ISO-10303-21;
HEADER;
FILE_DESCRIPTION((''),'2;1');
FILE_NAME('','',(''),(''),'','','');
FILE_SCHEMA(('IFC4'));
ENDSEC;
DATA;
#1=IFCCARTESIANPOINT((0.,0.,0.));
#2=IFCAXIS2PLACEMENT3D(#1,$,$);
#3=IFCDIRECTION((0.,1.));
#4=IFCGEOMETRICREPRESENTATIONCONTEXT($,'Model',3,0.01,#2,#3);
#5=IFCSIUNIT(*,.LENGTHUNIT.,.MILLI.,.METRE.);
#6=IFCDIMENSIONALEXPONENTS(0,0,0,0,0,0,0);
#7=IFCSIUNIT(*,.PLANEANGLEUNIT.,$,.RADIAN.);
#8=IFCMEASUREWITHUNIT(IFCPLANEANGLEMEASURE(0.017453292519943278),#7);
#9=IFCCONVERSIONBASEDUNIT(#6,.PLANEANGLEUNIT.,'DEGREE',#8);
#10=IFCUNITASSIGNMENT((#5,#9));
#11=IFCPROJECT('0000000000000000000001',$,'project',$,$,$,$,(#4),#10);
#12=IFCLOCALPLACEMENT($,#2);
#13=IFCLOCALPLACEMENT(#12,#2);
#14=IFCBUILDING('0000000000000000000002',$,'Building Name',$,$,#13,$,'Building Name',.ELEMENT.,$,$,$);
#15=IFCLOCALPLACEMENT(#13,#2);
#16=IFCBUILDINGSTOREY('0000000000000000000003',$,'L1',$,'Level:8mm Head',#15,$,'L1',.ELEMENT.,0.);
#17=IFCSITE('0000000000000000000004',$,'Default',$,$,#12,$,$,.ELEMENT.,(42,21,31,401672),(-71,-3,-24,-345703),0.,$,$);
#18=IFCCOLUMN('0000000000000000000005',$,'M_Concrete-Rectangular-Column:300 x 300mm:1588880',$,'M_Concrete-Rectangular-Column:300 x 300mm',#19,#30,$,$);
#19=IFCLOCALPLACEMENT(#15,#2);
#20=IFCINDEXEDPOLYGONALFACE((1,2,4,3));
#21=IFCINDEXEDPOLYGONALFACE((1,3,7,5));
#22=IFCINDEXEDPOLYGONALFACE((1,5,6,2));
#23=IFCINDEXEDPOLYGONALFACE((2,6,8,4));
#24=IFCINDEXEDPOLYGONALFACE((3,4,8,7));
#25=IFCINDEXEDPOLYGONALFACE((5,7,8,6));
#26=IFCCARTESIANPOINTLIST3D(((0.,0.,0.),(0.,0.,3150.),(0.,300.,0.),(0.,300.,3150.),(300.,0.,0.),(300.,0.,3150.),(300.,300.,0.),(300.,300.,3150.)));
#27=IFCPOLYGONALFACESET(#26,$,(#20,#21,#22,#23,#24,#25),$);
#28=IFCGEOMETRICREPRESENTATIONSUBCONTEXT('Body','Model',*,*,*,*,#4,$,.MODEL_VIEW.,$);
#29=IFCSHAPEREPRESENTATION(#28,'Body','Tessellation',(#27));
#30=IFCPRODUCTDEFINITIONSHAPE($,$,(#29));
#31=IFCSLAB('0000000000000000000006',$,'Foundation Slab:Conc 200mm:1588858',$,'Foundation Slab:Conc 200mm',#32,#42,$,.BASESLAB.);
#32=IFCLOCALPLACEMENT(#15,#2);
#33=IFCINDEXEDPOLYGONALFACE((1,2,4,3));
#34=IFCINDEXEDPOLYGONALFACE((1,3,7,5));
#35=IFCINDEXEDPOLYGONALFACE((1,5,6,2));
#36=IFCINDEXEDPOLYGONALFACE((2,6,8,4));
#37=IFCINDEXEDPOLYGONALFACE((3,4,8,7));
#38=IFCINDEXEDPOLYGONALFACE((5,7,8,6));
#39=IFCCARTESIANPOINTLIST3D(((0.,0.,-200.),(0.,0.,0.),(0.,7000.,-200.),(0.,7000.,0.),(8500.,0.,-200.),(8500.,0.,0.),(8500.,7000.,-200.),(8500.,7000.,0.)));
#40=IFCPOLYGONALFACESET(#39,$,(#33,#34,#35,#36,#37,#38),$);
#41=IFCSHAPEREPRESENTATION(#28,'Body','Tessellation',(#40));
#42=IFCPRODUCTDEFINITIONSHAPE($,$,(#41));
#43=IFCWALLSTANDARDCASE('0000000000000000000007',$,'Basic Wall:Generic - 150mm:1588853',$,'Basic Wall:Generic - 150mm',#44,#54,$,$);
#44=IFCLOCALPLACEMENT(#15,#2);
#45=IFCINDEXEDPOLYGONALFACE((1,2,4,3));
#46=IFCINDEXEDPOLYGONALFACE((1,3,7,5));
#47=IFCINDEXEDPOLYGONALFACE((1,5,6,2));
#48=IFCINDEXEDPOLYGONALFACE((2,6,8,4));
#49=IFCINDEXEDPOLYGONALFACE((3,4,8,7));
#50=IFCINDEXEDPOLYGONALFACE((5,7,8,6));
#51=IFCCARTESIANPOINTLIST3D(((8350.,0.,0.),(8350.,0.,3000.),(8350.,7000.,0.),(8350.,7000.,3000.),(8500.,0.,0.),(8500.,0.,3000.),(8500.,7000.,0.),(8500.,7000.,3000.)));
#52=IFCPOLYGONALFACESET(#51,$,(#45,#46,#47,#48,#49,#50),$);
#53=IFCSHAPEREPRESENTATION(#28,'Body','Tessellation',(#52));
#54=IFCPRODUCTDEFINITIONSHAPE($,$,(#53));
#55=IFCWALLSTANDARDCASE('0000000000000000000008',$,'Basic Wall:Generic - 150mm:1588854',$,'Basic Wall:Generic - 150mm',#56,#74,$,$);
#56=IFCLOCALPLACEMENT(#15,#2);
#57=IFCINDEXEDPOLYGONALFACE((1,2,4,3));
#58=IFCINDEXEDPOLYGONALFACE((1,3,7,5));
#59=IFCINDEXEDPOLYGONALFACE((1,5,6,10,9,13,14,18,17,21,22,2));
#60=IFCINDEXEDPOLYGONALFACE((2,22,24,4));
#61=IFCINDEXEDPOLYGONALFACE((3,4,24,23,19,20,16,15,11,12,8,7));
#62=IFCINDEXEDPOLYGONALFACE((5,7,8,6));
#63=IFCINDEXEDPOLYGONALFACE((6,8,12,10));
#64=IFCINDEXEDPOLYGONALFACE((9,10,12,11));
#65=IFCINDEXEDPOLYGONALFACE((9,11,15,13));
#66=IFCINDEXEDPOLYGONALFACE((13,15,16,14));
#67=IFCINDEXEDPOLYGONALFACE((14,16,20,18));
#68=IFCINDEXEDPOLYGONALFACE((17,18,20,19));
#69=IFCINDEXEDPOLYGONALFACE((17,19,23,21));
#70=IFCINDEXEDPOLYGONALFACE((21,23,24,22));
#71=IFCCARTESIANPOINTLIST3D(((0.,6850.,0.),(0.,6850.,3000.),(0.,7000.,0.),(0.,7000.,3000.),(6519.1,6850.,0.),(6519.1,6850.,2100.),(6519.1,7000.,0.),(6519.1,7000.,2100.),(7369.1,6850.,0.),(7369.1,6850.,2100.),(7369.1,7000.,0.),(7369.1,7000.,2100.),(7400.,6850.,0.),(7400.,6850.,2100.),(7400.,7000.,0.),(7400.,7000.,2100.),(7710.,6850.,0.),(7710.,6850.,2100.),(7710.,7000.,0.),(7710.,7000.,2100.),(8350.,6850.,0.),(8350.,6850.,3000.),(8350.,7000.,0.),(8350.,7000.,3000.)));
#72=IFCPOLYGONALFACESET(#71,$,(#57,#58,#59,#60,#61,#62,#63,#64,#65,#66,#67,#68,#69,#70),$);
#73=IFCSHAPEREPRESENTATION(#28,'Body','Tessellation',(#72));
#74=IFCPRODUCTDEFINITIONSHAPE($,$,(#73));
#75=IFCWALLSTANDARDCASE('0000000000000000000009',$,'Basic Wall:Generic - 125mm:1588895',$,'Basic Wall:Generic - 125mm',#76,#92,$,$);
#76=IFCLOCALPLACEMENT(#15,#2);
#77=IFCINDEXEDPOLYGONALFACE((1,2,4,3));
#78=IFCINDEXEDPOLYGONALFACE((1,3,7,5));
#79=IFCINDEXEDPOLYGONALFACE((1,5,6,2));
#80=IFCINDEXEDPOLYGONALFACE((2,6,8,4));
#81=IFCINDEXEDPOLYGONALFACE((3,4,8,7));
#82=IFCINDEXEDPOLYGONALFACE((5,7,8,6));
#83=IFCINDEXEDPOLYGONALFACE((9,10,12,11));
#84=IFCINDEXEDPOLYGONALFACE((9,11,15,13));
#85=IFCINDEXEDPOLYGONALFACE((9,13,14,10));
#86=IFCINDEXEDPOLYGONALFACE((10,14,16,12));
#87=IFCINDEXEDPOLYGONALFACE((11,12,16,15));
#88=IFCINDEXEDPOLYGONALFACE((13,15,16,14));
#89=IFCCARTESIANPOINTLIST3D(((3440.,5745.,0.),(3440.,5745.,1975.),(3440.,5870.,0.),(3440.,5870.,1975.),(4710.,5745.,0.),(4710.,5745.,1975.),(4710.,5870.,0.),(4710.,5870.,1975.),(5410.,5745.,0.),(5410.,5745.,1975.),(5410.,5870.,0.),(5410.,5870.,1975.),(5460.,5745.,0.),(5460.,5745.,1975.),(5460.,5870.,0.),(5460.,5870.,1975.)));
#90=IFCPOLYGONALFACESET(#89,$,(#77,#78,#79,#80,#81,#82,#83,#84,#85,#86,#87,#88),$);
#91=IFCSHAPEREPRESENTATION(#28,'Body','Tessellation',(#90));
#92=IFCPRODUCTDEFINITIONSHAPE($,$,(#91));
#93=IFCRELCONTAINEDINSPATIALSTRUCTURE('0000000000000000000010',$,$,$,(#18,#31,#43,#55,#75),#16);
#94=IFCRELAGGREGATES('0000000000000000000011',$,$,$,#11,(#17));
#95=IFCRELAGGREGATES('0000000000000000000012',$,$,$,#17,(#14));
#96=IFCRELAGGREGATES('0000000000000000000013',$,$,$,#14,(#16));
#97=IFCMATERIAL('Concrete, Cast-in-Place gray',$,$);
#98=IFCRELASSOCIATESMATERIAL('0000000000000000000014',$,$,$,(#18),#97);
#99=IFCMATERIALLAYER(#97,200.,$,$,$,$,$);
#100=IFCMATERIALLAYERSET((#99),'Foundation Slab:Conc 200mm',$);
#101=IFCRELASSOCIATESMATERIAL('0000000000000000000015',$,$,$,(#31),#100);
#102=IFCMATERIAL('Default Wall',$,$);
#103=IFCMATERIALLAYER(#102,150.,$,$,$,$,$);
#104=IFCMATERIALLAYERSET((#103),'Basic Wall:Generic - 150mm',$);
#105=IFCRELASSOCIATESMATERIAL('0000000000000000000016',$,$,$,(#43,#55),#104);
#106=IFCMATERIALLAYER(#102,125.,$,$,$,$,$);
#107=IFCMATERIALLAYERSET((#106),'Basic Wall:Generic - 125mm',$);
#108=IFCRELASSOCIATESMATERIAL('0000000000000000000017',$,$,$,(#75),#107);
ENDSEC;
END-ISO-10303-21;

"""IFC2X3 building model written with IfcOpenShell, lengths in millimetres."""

from ifc_helpers import new_model, entity, si_unit, converted_unit, direction, frame, frame_2d, origin, origin_2d_with_axis, place, context, subcontext, project, spatial, rectangle, extrude, source, transform, mapped, material, layer, layer_set, layer_usage, element, save


model = new_model("IFC2X3")

# Units and contexts
model_context = context("Model", 3, precision=0.01, world=origin(), true_north=direction((0.0, 1.0)))
body_context = subcontext(model_context, "Body", "Model", "MODEL_VIEW")
ifc_project = project(units=[si_unit("LENGTHUNIT", "METRE", prefix="MILLI"), converted_unit("PLANEANGLEUNIT", "DEGREE", entity("IfcPlaneAngleMeasure", 0.017453292519943278), si_unit("PLANEANGLEUNIT", "RADIAN"), dimensions=[0, 0, 0, 0, 0, 0, 0])], contexts=[model_context])

# Site, building, storey
site_placement = place(None, origin())
site = spatial("IfcSite", under=ifc_project, at=site_placement, Name="Default", CompositionType="ELEMENT", RefLatitude=(42, 21, 31, 401672), RefLongitude=(-71, -3, -24, -345703), RefElevation=0.0)
building_placement = place(site_placement, origin())
building = spatial("IfcBuilding", under=site, at=building_placement, Name="Building Name", LongName="Building Name", CompositionType="ELEMENT")
storey_placement = place(building_placement, origin())
storey = spatial("IfcBuildingStorey", under=building, at=storey_placement, Name="L1", ObjectType="Level:8mm Head", LongName="L1", CompositionType="ELEMENT", Elevation=0.0)

# Column
ifc_material_1 = material(Name="Concrete, Cast-in-Place gray")
shared_shape = source(origin(), body_context, "Body", "SweptSolid", [
    extrude(rectangle(XDim=300.0, YDim=300.0, at=origin_2d_with_axis()), frame((0.0, 0.0, 0.0), z_axis=(0.0, 0.0, 1.0), x_axis=(-1.0, 0.0, 0.0)), (0.0, 0.0, 1.0), 3150.0),
])
column_placement = place(storey_placement, frame((150.0, 150.0, 0.0)))
element("IfcColumn", 1, at=column_placement, inside=storey, material=ifc_material_1, Name="M_Concrete-Rectangular-Column:300 x 300mm:1588880", ObjectType="M_Concrete-Rectangular-Column:300 x 300mm", context=body_context, shape_type="MappedRepresentation", body=[
    mapped(shared_shape, transform((0.0, 0.0, 0.0), scale=1.0)),
])

# Slab
ifc_layer_1 = layer(ifc_material_1, 200.0)
ifc_layer_set_1 = layer_set([ifc_layer_1], Name="Foundation Slab:Conc 200mm")
ifc_layer_usage_1 = layer_usage(ifc_layer_set_1, "AXIS3", "POSITIVE", 0.0)
slab_placement = place(storey_placement, origin())
element("IfcSlab", 2, at=slab_placement, inside=storey, material=ifc_layer_usage_1, Name="Foundation Slab:Conc 200mm:1588858", ObjectType="Foundation Slab:Conc 200mm", PredefinedType="BASESLAB", context=body_context, shape_type="SweptSolid", body=[
    extrude(rectangle(XDim=7000.0, YDim=8500.0, at=origin_2d_with_axis()), frame((4250.0, 3500.0, 0.0), z_axis=(0.0, 0.0, -1.0), x_axis=(0.0, 1.0, 0.0)), (0.0, 0.0, 1.0), 200.0),
])

# Wall
ifc_material_2 = material(Name="Default Wall")
ifc_layer_2 = layer(ifc_material_2, 150.0)
ifc_layer_set_2 = layer_set([ifc_layer_2], Name="Basic Wall:Generic - 150mm")
ifc_layer_usage_2 = layer_usage(ifc_layer_set_2, "AXIS2", "NEGATIVE", 75.0)
wall_1_placement = place(storey_placement, frame((8425.0, 0.0, 0.0), z_axis=(0.0, 0.0, 1.0), x_axis=(0.0, 1.0, 0.0)))
element("IfcWallStandardCase", 3, at=wall_1_placement, inside=storey, material=ifc_layer_usage_2, Name="Basic Wall:Generic - 150mm:1588853", ObjectType="Basic Wall:Generic - 150mm", context=body_context, shape_type="SweptSolid", body=[
    extrude(rectangle(XDim=7000.0, YDim=150.0, at=frame_2d((3500.0, 0.0), x_axis=(-1.0, 0.0))), origin(), (0.0, 0.0, 1.0), 3000.0),
])

# Wall, openings
ifc_layer_usage_3 = layer_usage(ifc_layer_set_2, "AXIS2", "NEGATIVE", 75.0)
wall_2_placement = place(storey_placement, frame((8350.0, 6925.0, 0.0), z_axis=(0.0, 0.0, 1.0), x_axis=(-1.0, 0.0, 0.0)))
wall_2 = element("IfcWallStandardCase", 4, at=wall_2_placement, inside=storey, material=ifc_layer_usage_3, Name="Basic Wall:Generic - 150mm:1588854", ObjectType="Basic Wall:Generic - 150mm", context=body_context, shape_type="SweptSolid", body=[
    extrude(rectangle(XDim=8350.0, YDim=150.0, at=frame_2d((4175.0, 0.0), x_axis=(1.0, 0.0))), origin(), (0.0, 0.0, 1.0), 3000.0),
])
opening_1_placement = place(wall_2_placement, frame((980.9, -75.0, 0.0)))
element("IfcOpeningElement", 5, at=opening_1_placement, cuts=wall_2, ObjectType="Opening", context=body_context, shape_type="SweptSolid", body=[
    extrude(rectangle(XDim=2100.0, YDim=850.0, at=frame_2d((1050.0, 425.0), x_axis=(1.0, 0.0))), frame((0.0, 0.0, 0.0), z_axis=(0.0, 1.0, 0.0), x_axis=(0.0, 0.0, 1.0)), (0.0, 0.0, 1.0), 150.0),
])
opening_2_placement = place(wall_2_placement, frame((640.0, -75.0, 0.0)))
element("IfcOpeningElement", 6, at=opening_2_placement, cuts=wall_2, ObjectType="Opening", context=body_context, shape_type="SweptSolid", body=[
    extrude(rectangle(XDim=2100.0, YDim=310.0, at=frame_2d((1050.0, 155.0), x_axis=(-1.0, 0.0))), frame((0.0, 0.0, 0.0), z_axis=(0.0, 1.0, 0.0), x_axis=(0.0, 0.0, 1.0)), (0.0, 0.0, 1.0), 150.0),
])

# Wall, opening
ifc_layer_3 = layer(ifc_material_2, 125.0)
ifc_layer_set_3 = layer_set([ifc_layer_3], Name="Basic Wall:Generic - 125mm")
ifc_layer_usage_4 = layer_usage(ifc_layer_set_3, "AXIS2", "NEGATIVE", 62.5)
wall_3_placement = place(storey_placement, frame((3440.0, 5807.5, 0.0)))
wall_3 = element("IfcWallStandardCase", 7, at=wall_3_placement, inside=storey, material=ifc_layer_usage_4, Name="Basic Wall:Generic - 125mm:1588895", ObjectType="Basic Wall:Generic - 125mm", context=body_context, shape_type="SweptSolid", body=[
    extrude(rectangle(XDim=125.0, YDim=2020.0, at=frame_2d((1010.0, 0.0), x_axis=(0.0, -1.0))), origin(), (0.0, 0.0, 1.0), 1975.0),
])
opening_3_placement = place(wall_3_placement, frame((1970.0, 62.5, 0.0)))
element("IfcOpeningElement", 8, at=opening_3_placement, cuts=wall_3, ObjectType="Opening", context=body_context, shape_type="SweptSolid", body=[
    extrude(rectangle(XDim=2100.0, YDim=700.0, at=frame_2d((1050.0, 350.0), x_axis=(1.0, 0.0))), frame((0.0, 0.0, 0.0), z_axis=(0.0, -1.0, 0.0), x_axis=(0.0, 0.0, 1.0)), (0.0, 0.0, 1.0), 125.0),
])

save(model, "model.ifc")
